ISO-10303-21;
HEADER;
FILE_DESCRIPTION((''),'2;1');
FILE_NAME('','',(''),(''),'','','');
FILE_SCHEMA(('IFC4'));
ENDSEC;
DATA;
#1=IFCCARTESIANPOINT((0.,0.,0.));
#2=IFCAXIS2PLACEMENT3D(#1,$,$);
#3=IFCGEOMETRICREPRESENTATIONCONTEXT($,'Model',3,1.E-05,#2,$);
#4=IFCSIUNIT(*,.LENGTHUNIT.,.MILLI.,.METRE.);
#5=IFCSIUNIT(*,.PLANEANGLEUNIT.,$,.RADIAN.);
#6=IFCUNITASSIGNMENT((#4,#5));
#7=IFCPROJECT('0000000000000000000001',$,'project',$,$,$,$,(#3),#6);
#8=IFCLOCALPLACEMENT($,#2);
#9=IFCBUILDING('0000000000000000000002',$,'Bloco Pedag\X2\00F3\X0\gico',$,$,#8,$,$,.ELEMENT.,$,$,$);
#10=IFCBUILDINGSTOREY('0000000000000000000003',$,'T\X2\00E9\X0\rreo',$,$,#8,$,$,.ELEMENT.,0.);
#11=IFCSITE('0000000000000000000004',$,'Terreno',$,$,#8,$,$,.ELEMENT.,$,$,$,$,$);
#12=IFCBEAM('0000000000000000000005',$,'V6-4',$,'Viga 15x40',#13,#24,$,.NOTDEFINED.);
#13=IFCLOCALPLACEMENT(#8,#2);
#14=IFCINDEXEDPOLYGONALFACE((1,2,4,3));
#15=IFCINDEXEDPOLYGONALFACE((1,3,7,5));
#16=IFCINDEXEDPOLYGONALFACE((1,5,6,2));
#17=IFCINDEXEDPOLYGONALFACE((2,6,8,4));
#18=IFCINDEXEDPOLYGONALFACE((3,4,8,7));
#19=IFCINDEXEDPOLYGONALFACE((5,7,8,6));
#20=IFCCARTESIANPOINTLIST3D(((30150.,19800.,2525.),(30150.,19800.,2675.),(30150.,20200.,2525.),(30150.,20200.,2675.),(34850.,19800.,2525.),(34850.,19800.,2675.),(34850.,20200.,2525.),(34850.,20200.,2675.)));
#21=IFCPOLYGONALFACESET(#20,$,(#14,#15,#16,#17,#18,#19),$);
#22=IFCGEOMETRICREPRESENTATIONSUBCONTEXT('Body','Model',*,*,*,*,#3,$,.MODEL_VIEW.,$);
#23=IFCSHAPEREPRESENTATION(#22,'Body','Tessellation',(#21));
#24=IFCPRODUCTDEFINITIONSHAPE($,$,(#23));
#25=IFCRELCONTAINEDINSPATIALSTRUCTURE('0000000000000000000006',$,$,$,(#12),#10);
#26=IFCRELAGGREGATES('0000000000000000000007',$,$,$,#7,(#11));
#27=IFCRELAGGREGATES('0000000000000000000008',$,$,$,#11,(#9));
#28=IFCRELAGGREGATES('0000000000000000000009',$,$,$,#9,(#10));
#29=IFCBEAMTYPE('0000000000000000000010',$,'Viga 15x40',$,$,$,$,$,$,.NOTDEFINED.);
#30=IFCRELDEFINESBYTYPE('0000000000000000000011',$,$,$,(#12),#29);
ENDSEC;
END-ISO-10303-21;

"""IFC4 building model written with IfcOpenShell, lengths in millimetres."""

from ifc_helpers import new_model, si_unit, frame, origin, origin_2d, place, context, subcontext, project, spatial, rectangle, extrude, type_object, element, save


model = new_model("IFC4")

# Units and contexts
model_context = context("Model", 3, precision=1e-05, world=origin())
body_context = subcontext(model_context, "Body", "Model", "MODEL_VIEW")
ifc_project = project(units=[si_unit("LENGTHUNIT", "METRE", prefix="MILLI"), si_unit("PLANEANGLEUNIT", "RADIAN")], contexts=[model_context])

# Site, building, storey
placement = place(None, origin())
site = spatial("IfcSite", under=ifc_project, at=placement, Name="Terreno", CompositionType="ELEMENT")
building = spatial("IfcBuilding", under=site, at=placement, Name="Bloco Pedagógico", CompositionType="ELEMENT")
storey = spatial("IfcBuildingStorey", under=building, at=placement, Name="Térreo", CompositionType="ELEMENT", Elevation=0.0)

# Beam
beam_type = type_object("IfcBeamType", Name="Viga 15x40", PredefinedType="NOTDEFINED")
for number, where, z_axis, x_axis, name in (
    (1, (30150.0, 20000.0, 2600.0), (1.0, 0.0, 0.0), (0.0, 1.0, 0.0), "V6-4"),
):
    element("IfcBeam", number, at=place(None, frame(where, z_axis=z_axis, x_axis=x_axis)), inside=storey, type_object=beam_type, Name=name, ObjectType="Viga 15x40", PredefinedType="NOTDEFINED", context=body_context, shape_type="SweptSolid", body=[
        extrude(rectangle(XDim=400.0, YDim=150.0, at=origin_2d()), None, (0.0, 0.0, 1.0), 4700.0),
    ])

save(model, "model.ifc")
